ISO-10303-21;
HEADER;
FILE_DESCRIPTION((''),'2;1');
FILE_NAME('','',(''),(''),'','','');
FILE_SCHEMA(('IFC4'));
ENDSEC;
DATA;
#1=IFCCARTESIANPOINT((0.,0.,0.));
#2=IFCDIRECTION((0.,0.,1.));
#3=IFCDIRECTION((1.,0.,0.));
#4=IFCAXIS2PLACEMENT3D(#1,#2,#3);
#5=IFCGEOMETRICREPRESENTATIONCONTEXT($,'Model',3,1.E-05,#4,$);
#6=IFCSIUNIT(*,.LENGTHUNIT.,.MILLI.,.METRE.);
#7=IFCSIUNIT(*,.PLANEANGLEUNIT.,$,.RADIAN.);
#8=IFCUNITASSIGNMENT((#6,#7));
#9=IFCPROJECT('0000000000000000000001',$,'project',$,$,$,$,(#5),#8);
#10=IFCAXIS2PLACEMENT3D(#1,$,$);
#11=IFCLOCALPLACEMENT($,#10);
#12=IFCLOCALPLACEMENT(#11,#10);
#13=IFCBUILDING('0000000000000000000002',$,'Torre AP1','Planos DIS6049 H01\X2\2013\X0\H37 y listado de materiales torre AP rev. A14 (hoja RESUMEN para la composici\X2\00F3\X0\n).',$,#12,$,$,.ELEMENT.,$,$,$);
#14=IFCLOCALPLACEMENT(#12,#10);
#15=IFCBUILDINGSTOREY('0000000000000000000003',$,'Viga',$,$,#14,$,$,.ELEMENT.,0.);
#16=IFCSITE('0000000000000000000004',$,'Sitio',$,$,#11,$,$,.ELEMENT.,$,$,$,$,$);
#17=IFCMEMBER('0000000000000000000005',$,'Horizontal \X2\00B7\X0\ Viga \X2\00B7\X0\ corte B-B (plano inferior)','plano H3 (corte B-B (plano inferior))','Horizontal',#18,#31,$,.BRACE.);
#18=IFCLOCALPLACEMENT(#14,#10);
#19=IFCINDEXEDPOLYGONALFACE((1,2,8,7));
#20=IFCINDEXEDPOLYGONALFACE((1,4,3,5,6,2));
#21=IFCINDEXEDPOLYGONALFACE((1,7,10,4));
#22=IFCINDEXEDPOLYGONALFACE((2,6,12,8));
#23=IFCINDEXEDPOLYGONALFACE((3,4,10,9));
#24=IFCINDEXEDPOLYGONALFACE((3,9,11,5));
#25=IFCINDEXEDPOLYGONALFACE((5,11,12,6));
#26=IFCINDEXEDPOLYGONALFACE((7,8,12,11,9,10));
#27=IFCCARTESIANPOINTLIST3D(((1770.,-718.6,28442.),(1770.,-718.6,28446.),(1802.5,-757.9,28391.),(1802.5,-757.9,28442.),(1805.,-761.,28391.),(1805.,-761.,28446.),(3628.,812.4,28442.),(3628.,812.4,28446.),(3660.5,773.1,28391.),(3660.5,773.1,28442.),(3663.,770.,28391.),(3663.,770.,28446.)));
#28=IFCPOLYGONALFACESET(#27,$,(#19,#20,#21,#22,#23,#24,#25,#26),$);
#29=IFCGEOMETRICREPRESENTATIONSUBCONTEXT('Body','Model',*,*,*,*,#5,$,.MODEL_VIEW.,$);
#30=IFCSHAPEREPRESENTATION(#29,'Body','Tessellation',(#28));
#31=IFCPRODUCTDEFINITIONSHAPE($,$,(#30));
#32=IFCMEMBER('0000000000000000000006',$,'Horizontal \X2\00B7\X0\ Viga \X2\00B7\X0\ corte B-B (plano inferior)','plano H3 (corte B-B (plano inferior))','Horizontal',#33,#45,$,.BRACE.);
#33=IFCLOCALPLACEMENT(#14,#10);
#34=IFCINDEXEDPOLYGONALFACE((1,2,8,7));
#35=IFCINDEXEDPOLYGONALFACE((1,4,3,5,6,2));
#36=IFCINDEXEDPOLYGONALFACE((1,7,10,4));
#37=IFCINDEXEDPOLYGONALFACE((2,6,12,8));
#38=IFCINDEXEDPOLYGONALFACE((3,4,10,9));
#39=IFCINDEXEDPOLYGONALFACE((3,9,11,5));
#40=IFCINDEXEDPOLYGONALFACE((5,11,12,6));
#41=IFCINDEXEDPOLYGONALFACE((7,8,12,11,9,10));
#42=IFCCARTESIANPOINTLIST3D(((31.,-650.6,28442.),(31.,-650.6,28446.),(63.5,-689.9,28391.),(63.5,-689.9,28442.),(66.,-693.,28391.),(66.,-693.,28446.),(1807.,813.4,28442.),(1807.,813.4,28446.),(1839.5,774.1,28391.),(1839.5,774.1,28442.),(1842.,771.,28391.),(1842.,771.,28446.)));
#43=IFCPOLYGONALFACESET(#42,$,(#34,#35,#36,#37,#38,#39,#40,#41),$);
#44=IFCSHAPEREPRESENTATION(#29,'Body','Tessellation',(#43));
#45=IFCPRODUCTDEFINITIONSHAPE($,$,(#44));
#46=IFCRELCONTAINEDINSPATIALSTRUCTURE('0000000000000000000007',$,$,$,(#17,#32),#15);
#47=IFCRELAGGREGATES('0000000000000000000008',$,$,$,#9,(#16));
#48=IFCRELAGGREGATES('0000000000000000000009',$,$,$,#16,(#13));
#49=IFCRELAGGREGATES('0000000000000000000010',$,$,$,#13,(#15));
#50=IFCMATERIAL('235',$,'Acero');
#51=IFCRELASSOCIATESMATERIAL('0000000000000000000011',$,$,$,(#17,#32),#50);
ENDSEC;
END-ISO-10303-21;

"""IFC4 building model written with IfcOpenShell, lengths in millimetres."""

from ifc_helpers import new_model, si_unit, frame, frame_2d, origin, origin_with_axes, place, context, subcontext, project, spatial, l_section, extrude, material, element, save


model = new_model("IFC4")

# Units and contexts
model_context = context("Model", 3, precision=1e-05, world=origin_with_axes())
body_context = subcontext(model_context, "Body", "Model", "MODEL_VIEW")
ifc_project = project(units=[si_unit("LENGTHUNIT", "METRE", prefix="MILLI"), si_unit("PLANEANGLEUNIT", "RADIAN")], contexts=[model_context])

# Site, building, storey
site_placement = place(None, origin())
site = spatial("IfcSite", under=ifc_project, at=site_placement, Name="Sitio", CompositionType="ELEMENT")
building_placement = place(site_placement, origin())
building = spatial("IfcBuilding", under=site, at=building_placement, Name="Torre AP1", Description="Planos DIS6049 H01–H37 y listado de materiales torre AP rev. A14 (hoja RESUMEN para la composición).", CompositionType="ELEMENT")
storey_placement = place(building_placement, origin())
storey = spatial("IfcBuildingStorey", under=building, at=storey_placement, Name="Viga", CompositionType="ELEMENT", Elevation=0.0)

# Members
ifc_material = material(Name="235", Category="Acero")
member_1_placement = place(storey_placement, frame((3663.0, 770.0, 28446.0), z_axis=(-0.77175, -0.635926, 0.0), x_axis=(-0.635926, 0.77175, 0.0)))
element("IfcMember", 1, at=member_1_placement, inside=storey, material=ifc_material, Name="Horizontal · Viga · corte B-B (plano inferior)", Description="plano H3 (corte B-B (plano inferior))", ObjectType="Horizontal", PredefinedType="BRACE", context=body_context, shape_type="SweptSolid", body=[
    extrude(l_section(Depth=55.0, Width=55.0, Thickness=4.0, at=frame_2d((27.5, 27.5))), None, (0.0, 0.0, 1.0), 2407.5),
])
member_2_placement = place(storey_placement, frame((1842.0, 771.0, 28446.0), z_axis=(-0.771629, -0.636073, 0.0), x_axis=(-0.636073, 0.771629, 0.0)))
element("IfcMember", 2, at=member_2_placement, inside=storey, material=ifc_material, Name="Horizontal · Viga · corte B-B (plano inferior)", Description="plano H3 (corte B-B (plano inferior))", ObjectType="Horizontal", PredefinedType="BRACE", context=body_context, shape_type="SweptSolid", body=[
    extrude(l_section(Depth=55.0, Width=55.0, Thickness=4.0, at=frame_2d((27.5, 27.5))), None, (0.0, 0.0, 1.0), 2301.6),
])

save(model, "model.ifc")
